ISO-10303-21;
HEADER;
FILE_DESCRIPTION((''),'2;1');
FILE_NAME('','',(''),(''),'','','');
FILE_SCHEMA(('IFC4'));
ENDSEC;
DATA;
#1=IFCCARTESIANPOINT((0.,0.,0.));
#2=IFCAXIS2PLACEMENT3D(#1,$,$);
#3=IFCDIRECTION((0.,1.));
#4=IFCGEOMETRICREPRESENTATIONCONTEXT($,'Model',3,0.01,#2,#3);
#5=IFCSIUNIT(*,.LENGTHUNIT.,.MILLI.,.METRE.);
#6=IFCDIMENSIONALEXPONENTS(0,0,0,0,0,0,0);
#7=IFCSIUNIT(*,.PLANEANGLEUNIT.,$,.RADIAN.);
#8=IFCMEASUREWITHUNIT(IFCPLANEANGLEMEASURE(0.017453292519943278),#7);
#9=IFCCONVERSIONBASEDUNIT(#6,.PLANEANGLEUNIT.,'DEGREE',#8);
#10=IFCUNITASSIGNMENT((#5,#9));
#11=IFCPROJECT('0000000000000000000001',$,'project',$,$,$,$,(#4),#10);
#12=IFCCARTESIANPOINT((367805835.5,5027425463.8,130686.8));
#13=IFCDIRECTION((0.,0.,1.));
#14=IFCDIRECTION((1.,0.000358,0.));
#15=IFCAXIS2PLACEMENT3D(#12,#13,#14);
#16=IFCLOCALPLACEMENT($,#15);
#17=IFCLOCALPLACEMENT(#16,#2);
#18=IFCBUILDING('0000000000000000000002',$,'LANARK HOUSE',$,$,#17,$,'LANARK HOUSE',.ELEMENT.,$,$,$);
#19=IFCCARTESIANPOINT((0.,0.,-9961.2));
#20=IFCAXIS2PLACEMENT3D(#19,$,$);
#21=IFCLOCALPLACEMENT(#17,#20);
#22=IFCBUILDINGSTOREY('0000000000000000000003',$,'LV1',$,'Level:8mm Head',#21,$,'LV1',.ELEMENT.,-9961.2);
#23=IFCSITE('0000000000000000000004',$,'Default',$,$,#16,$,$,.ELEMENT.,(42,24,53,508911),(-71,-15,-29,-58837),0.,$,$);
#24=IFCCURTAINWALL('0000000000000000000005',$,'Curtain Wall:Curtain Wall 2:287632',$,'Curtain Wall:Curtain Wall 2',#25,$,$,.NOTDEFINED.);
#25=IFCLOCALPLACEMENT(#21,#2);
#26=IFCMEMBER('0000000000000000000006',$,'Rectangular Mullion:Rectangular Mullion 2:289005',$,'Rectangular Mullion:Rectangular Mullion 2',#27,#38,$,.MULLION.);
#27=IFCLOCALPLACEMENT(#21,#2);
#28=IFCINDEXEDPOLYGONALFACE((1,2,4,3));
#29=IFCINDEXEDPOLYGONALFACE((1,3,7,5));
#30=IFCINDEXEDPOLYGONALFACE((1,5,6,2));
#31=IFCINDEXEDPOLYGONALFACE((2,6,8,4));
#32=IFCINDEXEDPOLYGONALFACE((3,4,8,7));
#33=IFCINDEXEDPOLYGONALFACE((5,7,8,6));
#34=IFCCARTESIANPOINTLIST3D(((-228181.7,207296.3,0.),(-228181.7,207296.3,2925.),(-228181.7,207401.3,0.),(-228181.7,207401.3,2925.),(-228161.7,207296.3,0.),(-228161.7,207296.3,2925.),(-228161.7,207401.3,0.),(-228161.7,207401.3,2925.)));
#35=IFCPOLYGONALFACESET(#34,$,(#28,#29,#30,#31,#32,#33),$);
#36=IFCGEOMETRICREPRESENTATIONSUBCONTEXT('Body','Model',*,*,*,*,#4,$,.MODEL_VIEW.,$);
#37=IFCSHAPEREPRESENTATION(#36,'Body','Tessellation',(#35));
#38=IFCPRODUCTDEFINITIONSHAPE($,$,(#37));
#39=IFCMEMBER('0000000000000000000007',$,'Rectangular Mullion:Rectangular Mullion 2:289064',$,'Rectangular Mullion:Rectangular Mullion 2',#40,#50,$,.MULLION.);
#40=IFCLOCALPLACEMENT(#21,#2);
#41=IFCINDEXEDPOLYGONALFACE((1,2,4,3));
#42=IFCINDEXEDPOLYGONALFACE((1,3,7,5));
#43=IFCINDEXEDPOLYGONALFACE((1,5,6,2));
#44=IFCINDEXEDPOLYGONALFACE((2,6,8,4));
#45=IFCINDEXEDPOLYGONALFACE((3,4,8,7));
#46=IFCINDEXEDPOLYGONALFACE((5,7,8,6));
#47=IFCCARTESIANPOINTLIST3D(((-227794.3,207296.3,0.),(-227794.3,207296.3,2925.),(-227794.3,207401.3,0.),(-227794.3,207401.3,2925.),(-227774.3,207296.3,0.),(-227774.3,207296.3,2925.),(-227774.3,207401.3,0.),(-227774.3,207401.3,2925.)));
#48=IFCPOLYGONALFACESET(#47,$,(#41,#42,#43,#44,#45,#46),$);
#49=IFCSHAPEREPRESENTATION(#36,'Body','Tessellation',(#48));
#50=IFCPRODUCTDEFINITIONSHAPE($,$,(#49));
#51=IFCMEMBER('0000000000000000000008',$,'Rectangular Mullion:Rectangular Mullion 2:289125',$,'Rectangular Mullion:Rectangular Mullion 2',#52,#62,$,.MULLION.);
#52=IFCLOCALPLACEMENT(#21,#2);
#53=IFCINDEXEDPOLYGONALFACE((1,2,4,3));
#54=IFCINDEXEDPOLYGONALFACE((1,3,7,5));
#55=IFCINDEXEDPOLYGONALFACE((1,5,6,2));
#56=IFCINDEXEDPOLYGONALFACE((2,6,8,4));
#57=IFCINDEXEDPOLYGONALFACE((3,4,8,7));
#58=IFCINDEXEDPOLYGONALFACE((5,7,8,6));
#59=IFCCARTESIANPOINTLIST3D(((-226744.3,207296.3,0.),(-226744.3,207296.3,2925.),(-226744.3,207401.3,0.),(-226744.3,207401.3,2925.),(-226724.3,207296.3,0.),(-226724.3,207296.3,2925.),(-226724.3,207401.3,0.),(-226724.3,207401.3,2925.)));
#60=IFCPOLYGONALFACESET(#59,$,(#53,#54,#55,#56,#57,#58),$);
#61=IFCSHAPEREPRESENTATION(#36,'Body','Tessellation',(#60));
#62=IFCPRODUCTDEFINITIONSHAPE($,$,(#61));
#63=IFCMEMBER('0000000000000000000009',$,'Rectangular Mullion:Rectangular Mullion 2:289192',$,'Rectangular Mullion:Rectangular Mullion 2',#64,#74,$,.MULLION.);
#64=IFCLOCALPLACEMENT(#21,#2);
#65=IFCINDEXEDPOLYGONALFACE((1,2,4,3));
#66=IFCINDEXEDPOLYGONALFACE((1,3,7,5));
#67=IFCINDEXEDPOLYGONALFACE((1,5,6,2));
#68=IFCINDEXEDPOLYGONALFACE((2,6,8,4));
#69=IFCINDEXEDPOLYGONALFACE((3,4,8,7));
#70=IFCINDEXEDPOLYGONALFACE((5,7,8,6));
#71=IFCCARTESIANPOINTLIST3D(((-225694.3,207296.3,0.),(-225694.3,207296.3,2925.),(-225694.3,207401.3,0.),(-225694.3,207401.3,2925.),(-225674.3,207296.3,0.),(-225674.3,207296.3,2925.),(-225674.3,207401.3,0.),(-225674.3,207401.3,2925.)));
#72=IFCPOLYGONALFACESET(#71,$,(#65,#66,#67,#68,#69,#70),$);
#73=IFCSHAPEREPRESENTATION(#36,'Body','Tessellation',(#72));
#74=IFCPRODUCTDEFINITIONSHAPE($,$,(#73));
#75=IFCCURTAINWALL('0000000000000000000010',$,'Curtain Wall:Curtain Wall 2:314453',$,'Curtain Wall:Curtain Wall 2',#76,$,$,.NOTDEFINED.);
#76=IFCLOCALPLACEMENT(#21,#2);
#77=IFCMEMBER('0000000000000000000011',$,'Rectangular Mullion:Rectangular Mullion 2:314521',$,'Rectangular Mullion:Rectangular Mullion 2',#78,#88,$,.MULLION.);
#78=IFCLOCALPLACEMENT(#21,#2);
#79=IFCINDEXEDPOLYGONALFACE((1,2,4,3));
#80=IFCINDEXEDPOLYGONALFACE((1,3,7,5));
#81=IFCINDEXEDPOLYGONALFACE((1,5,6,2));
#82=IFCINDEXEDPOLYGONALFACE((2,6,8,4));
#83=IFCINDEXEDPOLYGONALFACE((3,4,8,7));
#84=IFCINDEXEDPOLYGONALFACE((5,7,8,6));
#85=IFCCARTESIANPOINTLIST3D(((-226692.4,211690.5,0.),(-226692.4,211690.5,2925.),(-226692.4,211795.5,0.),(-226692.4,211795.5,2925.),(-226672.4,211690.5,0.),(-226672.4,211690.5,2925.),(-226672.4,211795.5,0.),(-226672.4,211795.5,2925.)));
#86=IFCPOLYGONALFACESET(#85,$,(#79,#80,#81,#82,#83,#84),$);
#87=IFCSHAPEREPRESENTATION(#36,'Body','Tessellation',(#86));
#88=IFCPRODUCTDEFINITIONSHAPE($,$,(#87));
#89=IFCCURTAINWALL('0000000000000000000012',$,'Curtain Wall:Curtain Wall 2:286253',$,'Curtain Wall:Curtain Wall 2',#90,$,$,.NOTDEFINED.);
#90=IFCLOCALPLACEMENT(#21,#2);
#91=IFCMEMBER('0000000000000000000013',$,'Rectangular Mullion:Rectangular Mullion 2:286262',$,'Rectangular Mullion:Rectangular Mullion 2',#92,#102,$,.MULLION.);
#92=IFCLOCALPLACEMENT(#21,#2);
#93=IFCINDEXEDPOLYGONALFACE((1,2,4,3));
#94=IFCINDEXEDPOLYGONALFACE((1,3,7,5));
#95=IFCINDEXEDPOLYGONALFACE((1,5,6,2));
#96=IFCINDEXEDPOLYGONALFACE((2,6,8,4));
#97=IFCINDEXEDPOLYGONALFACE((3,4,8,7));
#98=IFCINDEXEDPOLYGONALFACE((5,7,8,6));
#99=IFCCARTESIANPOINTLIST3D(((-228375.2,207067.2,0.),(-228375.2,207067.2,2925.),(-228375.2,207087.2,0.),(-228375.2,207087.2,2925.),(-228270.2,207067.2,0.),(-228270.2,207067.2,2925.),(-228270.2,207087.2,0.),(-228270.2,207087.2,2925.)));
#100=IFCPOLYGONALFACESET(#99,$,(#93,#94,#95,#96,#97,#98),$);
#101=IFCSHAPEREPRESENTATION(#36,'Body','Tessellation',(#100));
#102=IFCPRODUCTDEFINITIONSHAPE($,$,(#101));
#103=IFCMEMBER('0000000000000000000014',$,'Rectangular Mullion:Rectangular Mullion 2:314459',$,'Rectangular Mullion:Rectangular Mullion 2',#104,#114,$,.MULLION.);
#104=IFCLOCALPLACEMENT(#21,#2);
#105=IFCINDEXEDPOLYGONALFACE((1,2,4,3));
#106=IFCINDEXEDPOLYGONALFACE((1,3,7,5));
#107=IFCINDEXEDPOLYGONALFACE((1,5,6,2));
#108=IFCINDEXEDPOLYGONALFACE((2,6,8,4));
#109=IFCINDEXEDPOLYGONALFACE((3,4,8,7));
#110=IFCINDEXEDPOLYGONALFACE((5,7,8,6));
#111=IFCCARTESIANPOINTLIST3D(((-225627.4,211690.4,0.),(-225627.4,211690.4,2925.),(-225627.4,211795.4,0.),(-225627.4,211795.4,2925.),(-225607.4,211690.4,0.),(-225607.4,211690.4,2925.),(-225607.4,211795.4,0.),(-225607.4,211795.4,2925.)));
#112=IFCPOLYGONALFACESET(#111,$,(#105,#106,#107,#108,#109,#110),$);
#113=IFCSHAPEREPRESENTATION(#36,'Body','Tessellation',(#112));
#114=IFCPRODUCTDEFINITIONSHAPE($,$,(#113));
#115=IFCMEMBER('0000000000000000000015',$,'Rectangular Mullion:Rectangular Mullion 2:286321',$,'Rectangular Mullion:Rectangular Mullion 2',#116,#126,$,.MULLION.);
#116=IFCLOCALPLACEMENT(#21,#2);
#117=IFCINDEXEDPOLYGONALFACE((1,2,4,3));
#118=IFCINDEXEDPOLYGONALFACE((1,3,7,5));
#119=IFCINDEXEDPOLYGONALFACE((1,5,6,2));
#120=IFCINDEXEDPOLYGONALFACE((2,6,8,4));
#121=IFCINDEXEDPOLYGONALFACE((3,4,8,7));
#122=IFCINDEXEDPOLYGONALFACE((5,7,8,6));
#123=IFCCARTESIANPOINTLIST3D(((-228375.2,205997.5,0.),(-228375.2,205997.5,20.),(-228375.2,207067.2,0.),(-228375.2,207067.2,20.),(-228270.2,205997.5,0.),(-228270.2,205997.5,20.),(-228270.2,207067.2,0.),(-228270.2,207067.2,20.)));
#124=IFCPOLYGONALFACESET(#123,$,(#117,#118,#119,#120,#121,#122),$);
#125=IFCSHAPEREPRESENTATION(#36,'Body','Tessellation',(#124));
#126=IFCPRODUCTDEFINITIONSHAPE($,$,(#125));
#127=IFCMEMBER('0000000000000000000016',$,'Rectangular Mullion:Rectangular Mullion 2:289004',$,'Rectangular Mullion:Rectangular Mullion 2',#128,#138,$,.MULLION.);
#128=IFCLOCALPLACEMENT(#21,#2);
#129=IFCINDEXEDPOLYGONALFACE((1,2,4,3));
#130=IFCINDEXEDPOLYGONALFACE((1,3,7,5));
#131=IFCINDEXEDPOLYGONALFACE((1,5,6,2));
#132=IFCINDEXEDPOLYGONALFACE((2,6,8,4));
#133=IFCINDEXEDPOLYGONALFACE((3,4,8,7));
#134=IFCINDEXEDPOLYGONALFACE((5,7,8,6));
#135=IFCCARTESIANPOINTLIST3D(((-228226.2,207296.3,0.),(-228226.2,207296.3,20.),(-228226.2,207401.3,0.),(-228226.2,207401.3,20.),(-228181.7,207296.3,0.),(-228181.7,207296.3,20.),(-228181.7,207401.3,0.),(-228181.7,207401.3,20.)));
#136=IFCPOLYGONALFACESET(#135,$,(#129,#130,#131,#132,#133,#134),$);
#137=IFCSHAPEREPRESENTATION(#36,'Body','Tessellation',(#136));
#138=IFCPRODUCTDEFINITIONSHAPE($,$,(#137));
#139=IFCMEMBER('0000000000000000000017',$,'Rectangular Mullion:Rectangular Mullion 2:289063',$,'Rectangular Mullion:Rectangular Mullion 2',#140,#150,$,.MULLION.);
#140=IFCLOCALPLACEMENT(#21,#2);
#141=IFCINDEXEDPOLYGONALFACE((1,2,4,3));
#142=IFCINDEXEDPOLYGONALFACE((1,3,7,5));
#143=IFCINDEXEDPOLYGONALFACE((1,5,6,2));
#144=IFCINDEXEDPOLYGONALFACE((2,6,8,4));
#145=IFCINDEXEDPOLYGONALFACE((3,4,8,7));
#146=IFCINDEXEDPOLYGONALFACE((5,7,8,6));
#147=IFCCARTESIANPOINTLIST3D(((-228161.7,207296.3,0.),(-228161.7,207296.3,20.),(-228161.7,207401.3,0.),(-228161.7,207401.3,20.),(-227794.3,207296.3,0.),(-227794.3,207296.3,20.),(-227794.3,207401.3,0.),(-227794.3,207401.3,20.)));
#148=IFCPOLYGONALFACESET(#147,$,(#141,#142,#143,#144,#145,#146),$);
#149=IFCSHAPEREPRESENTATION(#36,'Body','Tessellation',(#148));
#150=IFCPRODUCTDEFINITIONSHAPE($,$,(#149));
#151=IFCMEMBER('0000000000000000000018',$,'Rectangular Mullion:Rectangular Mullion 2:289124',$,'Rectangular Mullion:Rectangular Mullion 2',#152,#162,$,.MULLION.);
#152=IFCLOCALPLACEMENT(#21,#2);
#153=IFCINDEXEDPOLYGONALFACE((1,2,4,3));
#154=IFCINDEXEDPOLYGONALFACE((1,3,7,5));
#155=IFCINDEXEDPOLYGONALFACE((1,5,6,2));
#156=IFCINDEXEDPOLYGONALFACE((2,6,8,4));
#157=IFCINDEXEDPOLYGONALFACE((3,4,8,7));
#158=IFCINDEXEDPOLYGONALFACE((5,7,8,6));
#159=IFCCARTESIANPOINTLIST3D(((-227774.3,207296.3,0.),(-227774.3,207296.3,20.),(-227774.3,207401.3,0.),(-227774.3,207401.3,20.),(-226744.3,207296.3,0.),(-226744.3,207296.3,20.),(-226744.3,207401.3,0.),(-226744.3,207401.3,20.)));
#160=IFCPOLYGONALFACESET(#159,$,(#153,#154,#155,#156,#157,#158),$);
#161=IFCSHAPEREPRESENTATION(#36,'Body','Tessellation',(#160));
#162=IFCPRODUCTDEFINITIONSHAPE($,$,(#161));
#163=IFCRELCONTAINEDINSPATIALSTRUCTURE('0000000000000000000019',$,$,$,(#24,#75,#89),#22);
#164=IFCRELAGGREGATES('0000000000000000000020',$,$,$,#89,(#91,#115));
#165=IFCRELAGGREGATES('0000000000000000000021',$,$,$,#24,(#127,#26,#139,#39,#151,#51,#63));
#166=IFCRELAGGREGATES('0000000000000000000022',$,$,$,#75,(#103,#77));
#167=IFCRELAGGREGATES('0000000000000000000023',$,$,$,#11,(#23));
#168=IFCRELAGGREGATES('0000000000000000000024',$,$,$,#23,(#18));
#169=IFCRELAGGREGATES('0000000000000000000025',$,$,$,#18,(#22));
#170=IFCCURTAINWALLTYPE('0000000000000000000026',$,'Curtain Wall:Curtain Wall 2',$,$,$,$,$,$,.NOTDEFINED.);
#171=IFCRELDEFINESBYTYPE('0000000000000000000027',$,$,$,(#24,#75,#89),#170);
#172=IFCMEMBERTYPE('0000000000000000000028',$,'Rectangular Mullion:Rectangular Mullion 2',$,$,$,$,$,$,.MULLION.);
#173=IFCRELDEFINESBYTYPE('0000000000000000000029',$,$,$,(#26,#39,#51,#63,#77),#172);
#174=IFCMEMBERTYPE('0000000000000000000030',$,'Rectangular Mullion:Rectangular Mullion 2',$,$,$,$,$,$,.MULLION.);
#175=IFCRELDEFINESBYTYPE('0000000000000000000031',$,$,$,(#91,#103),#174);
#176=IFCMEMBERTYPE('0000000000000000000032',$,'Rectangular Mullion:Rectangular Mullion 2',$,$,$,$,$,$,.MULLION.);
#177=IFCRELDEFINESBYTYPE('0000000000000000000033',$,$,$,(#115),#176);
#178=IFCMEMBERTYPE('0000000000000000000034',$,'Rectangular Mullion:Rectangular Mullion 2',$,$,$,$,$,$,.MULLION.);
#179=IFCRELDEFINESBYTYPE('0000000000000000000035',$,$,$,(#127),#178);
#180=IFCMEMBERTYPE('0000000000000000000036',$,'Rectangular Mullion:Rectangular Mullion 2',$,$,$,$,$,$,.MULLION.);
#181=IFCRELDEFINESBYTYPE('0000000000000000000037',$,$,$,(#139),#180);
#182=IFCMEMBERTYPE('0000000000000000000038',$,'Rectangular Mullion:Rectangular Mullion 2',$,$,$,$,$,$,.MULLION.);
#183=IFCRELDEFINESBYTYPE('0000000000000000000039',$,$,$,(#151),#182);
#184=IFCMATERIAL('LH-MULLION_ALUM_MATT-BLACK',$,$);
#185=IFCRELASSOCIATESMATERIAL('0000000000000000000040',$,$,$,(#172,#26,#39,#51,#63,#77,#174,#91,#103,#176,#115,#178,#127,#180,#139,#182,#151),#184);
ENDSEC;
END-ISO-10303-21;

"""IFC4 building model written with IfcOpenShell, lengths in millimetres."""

from ifc_helpers import new_model, entity, si_unit, converted_unit, direction, frame, origin, place, context, subcontext, project, spatial, indexed_curve, outline, extrude, source, transform, mapped, material, type_object, type_shapes, element, aggregate, save


model = new_model("IFC4")

# Units and contexts
model_context = context("Model", 3, precision=0.01, world=origin(), true_north=direction((0.0, 1.0)))
body_context = subcontext(model_context, "Body", "Model", "MODEL_VIEW")
ifc_project = project(units=[si_unit("LENGTHUNIT", "METRE", prefix="MILLI"), converted_unit("PLANEANGLEUNIT", "DEGREE", entity("IfcPlaneAngleMeasure", 0.017453292519943278), si_unit("PLANEANGLEUNIT", "RADIAN"), dimensions=[0, 0, 0, 0, 0, 0, 0])], contexts=[model_context])

# Site, building, storey
site_placement = place(None, frame((367805835.5, 5027425463.8, 130686.8), z_axis=(0.0, 0.0, 1.0), x_axis=(1.0, 0.000358, 0.0)))
site = spatial("IfcSite", under=ifc_project, at=site_placement, Name="Default", CompositionType="ELEMENT", RefLatitude=(42, 24, 53, 508911), RefLongitude=(-71, -15, -29, -58837), RefElevation=0.0)
building_placement = place(site_placement, origin())
building = spatial("IfcBuilding", under=site, at=building_placement, Name="LANARK HOUSE", LongName="LANARK HOUSE", CompositionType="ELEMENT")
storey_placement = place(building_placement, frame((0.0, 0.0, -9961.2)))
storey = spatial("IfcBuildingStorey", under=building, at=storey_placement, Name="LV1", ObjectType="Level:8mm Head", LongName="LV1", CompositionType="ELEMENT", Elevation=-9961.2)

# Curtain wall, members
curtain_wall_type_1 = type_object("IfcCurtainWallType", Name="Curtain Wall:Curtain Wall 2", PredefinedType="NOTDEFINED")
curtain_wall_1_placement = place(storey_placement, frame((0.0, 0.0, 9961.2)))
curtain_wall_1 = element("IfcCurtainWall", 1, at=curtain_wall_1_placement, inside=storey, type_object=curtain_wall_type_1, Name="Curtain Wall:Curtain Wall 2:287632", ObjectType="Curtain Wall:Curtain Wall 2", PredefinedType="NOTDEFINED")
ifc_material_1 = material(Name="LH-MULLION_ALUM_MATT-BLACK")
member_type_1 = type_object("IfcMemberType", Name="Rectangular Mullion:Rectangular Mullion 2", PredefinedType="MULLION", material=ifc_material_1)
shared_shape_1 = source(origin(), body_context, "Body", "SweptSolid", [
    extrude(outline(indexed_curve([(-10.0, -52.5), (10.0, -52.5), (10.0, 52.5), (-10.0, 52.5), (-10.0, -52.5)], self_intersect=False)), frame((0.0, -40.0, -2925.0), z_axis=(0.0, 0.0, 1.0), x_axis=(-1.0, 0.0, 0.0)), (0.0, 0.0, 1.0), 2925.0),
])
type_shapes(member_type_1, [shared_shape_1])
member_1_placement = place(curtain_wall_1_placement, frame((-228171.7, 207388.8, -9961.2), z_axis=(0.0, 0.0, -1.0), x_axis=(-1.0, 0.0, 0.0)))
member_1 = element("IfcMember", 2, at=member_1_placement, type_object=member_type_1, material=ifc_material_1, Name="Rectangular Mullion:Rectangular Mullion 2:289005", ObjectType="Rectangular Mullion:Rectangular Mullion 2", PredefinedType="MULLION", context=body_context, shape_type="MappedRepresentation", body=[
    mapped(shared_shape_1, transform((0.0, 0.0, 0.0), scale=1.0)),
])
member_2_placement = place(curtain_wall_1_placement, frame((-227784.3, 207388.8, -9961.2), z_axis=(0.0, 0.0, -1.0), x_axis=(-1.0, 0.0, 0.0)))
member_2 = element("IfcMember", 3, at=member_2_placement, type_object=member_type_1, material=ifc_material_1, Name="Rectangular Mullion:Rectangular Mullion 2:289064", ObjectType="Rectangular Mullion:Rectangular Mullion 2", PredefinedType="MULLION", context=body_context, shape_type="MappedRepresentation", body=[
    mapped(shared_shape_1, transform((0.0, 0.0, 0.0), scale=1.0)),
])
member_3_placement = place(curtain_wall_1_placement, frame((-226734.3, 207388.8, -9961.2), z_axis=(0.0, 0.0, -1.0), x_axis=(-1.0, 0.0, 0.0)))
member_3 = element("IfcMember", 4, at=member_3_placement, type_object=member_type_1, material=ifc_material_1, Name="Rectangular Mullion:Rectangular Mullion 2:289125", ObjectType="Rectangular Mullion:Rectangular Mullion 2", PredefinedType="MULLION", context=body_context, shape_type="MappedRepresentation", body=[
    mapped(shared_shape_1, transform((0.0, 0.0, 0.0), scale=1.0)),
])
member_4_placement = place(curtain_wall_1_placement, frame((-225684.3, 207388.8, -9961.2), z_axis=(0.0, 0.0, -1.0), x_axis=(-1.0, 0.0, 0.0)))
member_4 = element("IfcMember", 5, at=member_4_placement, type_object=member_type_1, material=ifc_material_1, Name="Rectangular Mullion:Rectangular Mullion 2:289192", ObjectType="Rectangular Mullion:Rectangular Mullion 2", PredefinedType="MULLION", context=body_context, shape_type="MappedRepresentation", body=[
    mapped(shared_shape_1, transform((0.0, 0.0, 0.0), scale=1.0)),
])

# Curtain walls, members
curtain_wall_2_placement = place(storey_placement, frame((0.0, 0.0, 9961.2)))
curtain_wall_2 = element("IfcCurtainWall", 6, at=curtain_wall_2_placement, inside=storey, type_object=curtain_wall_type_1, Name="Curtain Wall:Curtain Wall 2:314453", ObjectType="Curtain Wall:Curtain Wall 2", PredefinedType="NOTDEFINED")
member_5_placement = place(curtain_wall_2_placement, frame((-226682.4, 211703.0, -9961.2), z_axis=(0.0, 0.0, -1.0), x_axis=(1.0, 0.0, 0.0)))
member_5 = element("IfcMember", 7, at=member_5_placement, type_object=member_type_1, material=ifc_material_1, Name="Rectangular Mullion:Rectangular Mullion 2:314521", ObjectType="Rectangular Mullion:Rectangular Mullion 2", PredefinedType="MULLION", context=body_context, shape_type="MappedRepresentation", body=[
    mapped(shared_shape_1, transform((0.0, 0.0, 0.0), scale=1.0)),
])
curtain_wall_3_placement = place(storey_placement, frame((0.0, 0.0, 9961.2)))
curtain_wall_3 = element("IfcCurtainWall", 8, at=curtain_wall_3_placement, inside=storey, type_object=curtain_wall_type_1, Name="Curtain Wall:Curtain Wall 2:286253", ObjectType="Curtain Wall:Curtain Wall 2", PredefinedType="NOTDEFINED")
member_type_2 = type_object("IfcMemberType", Name="Rectangular Mullion:Rectangular Mullion 2", PredefinedType="MULLION", material=ifc_material_1)
shared_shape_2 = source(origin(), body_context, "Body", "SweptSolid", [
    extrude(outline(indexed_curve([(-10.0, -52.5), (10.0, -52.5), (10.0, 52.5), (-10.0, 52.5), (-10.0, -52.5)], self_intersect=False)), frame((-10.0, -40.0, -2925.0), z_axis=(0.0, 0.0, 1.0), x_axis=(-1.0, 0.0, 0.0)), (0.0, 0.0, 1.0), 2925.0),
])
type_shapes(member_type_2, [shared_shape_2])
member_6_placement = place(curtain_wall_3_placement, frame((-228282.7, 207087.2, -9961.2), z_axis=(0.0, 0.0, -1.0), x_axis=(0.0, 1.0, 0.0)))
member_6 = element("IfcMember", 9, at=member_6_placement, type_object=member_type_2, material=ifc_material_1, Name="Rectangular Mullion:Rectangular Mullion 2:286262", ObjectType="Rectangular Mullion:Rectangular Mullion 2", PredefinedType="MULLION", context=body_context, shape_type="MappedRepresentation", body=[
    mapped(shared_shape_2, transform((0.0, 0.0, 0.0), scale=1.0)),
])

# Members
member_7_placement = place(curtain_wall_2_placement, frame((-225607.4, 211702.9, -9961.2), z_axis=(0.0, 0.0, -1.0), x_axis=(1.0, 0.0, 0.0)))
member_7 = element("IfcMember", 10, at=member_7_placement, type_object=member_type_2, material=ifc_material_1, Name="Rectangular Mullion:Rectangular Mullion 2:314459", ObjectType="Rectangular Mullion:Rectangular Mullion 2", PredefinedType="MULLION", context=body_context, shape_type="MappedRepresentation", body=[
    mapped(shared_shape_2, transform((0.0, 0.0, 0.0), scale=1.0)),
])
member_type_3 = type_object("IfcMemberType", Name="Rectangular Mullion:Rectangular Mullion 2", PredefinedType="MULLION", material=ifc_material_1)
shared_shape_3 = source(origin(), body_context, "Body", "SweptSolid", [
    extrude(outline(indexed_curve([(-10.0, -52.5), (10.0, -52.5), (10.0, 52.5), (-10.0, 52.5), (-10.0, -52.5)], self_intersect=False)), frame((-10.0, -40.0, -1069.7), z_axis=(0.0, 0.0, 1.0), x_axis=(-1.0, 0.0, 0.0)), (0.0, 0.0, 1.0), 1069.7),
])
type_shapes(member_type_3, [shared_shape_3])
member_8_placement = place(curtain_wall_3_placement, frame((-228282.7, 205997.5, -9961.2), z_axis=(0.0, -1.0, 0.0), x_axis=(0.0, 0.0, -1.0)))
member_8 = element("IfcMember", 11, at=member_8_placement, type_object=member_type_3, material=ifc_material_1, Name="Rectangular Mullion:Rectangular Mullion 2:286321", ObjectType="Rectangular Mullion:Rectangular Mullion 2", PredefinedType="MULLION", context=body_context, shape_type="MappedRepresentation", body=[
    mapped(shared_shape_3, transform((0.0, 0.0, 0.0), scale=1.0)),
])
aggregate(curtain_wall_3, [member_6, member_8])
member_type_4 = type_object("IfcMemberType", Name="Rectangular Mullion:Rectangular Mullion 2", PredefinedType="MULLION", material=ifc_material_1)
shared_shape_4 = source(origin(), body_context, "Body", "SweptSolid", [
    extrude(outline(indexed_curve([(-10.0, -52.5), (10.0, -52.5), (10.0, 52.5), (-10.0, 52.5), (-10.0, -52.5)], self_intersect=False)), frame((-10.0, -40.0, -44.5), z_axis=(0.0, 0.0, 1.0), x_axis=(-1.0, 0.0, 0.0)), (0.0, 0.0, 1.0), 44.5),
])
type_shapes(member_type_4, [shared_shape_4])
member_9_placement = place(curtain_wall_1_placement, frame((-228181.7, 207388.8, -9961.2), z_axis=(1.0, 0.0, 0.0), x_axis=(0.0, 0.0, -1.0)))
member_9 = element("IfcMember", 12, at=member_9_placement, type_object=member_type_4, material=ifc_material_1, Name="Rectangular Mullion:Rectangular Mullion 2:289004", ObjectType="Rectangular Mullion:Rectangular Mullion 2", PredefinedType="MULLION", context=body_context, shape_type="MappedRepresentation", body=[
    mapped(shared_shape_4, transform((0.0, 0.0, 0.0), scale=1.0)),
])
member_type_5 = type_object("IfcMemberType", Name="Rectangular Mullion:Rectangular Mullion 2", PredefinedType="MULLION", material=ifc_material_1)
shared_shape_5 = source(origin(), body_context, "Body", "SweptSolid", [
    extrude(outline(indexed_curve([(-10.0, -52.5), (10.0, -52.5), (10.0, 52.5), (-10.0, 52.5), (-10.0, -52.5)], self_intersect=False)), frame((-10.0, -40.0, -367.4), z_axis=(0.0, 0.0, 1.0), x_axis=(-1.0, 0.0, 0.0)), (0.0, 0.0, 1.0), 367.4),
])
type_shapes(member_type_5, [shared_shape_5])
member_10_placement = place(curtain_wall_1_placement, frame((-227794.3, 207388.8, -9961.2), z_axis=(1.0, 0.0, 0.0), x_axis=(0.0, 0.0, -1.0)))
member_10 = element("IfcMember", 13, at=member_10_placement, type_object=member_type_5, material=ifc_material_1, Name="Rectangular Mullion:Rectangular Mullion 2:289063", ObjectType="Rectangular Mullion:Rectangular Mullion 2", PredefinedType="MULLION", context=body_context, shape_type="MappedRepresentation", body=[
    mapped(shared_shape_5, transform((0.0, 0.0, 0.0), scale=1.0)),
])
member_type_6 = type_object("IfcMemberType", Name="Rectangular Mullion:Rectangular Mullion 2", PredefinedType="MULLION", material=ifc_material_1)
shared_shape_6 = source(origin(), body_context, "Body", "SweptSolid", [
    extrude(outline(indexed_curve([(-10.0, -52.5), (10.0, -52.5), (10.0, 52.5), (-10.0, 52.5), (-10.0, -52.5)], self_intersect=False)), frame((-10.0, -40.0, -1030.0), z_axis=(0.0, 0.0, 1.0), x_axis=(-1.0, 0.0, 0.0)), (0.0, 0.0, 1.0), 1030.0),
])
type_shapes(member_type_6, [shared_shape_6])
member_11_placement = place(curtain_wall_1_placement, frame((-226744.3, 207388.8, -9961.2), z_axis=(1.0, 0.0, 0.0), x_axis=(0.0, 0.0, -1.0)))
member_11 = element("IfcMember", 14, at=member_11_placement, type_object=member_type_6, material=ifc_material_1, Name="Rectangular Mullion:Rectangular Mullion 2:289124", ObjectType="Rectangular Mullion:Rectangular Mullion 2", PredefinedType="MULLION", context=body_context, shape_type="MappedRepresentation", body=[
    mapped(shared_shape_6, transform((0.0, 0.0, 0.0), scale=1.0)),
])
aggregate(curtain_wall_1, [member_9, member_1, member_10, member_2, member_11, member_3, member_4])

aggregate(curtain_wall_2, [member_7, member_5])

save(model, "model.ifc")
